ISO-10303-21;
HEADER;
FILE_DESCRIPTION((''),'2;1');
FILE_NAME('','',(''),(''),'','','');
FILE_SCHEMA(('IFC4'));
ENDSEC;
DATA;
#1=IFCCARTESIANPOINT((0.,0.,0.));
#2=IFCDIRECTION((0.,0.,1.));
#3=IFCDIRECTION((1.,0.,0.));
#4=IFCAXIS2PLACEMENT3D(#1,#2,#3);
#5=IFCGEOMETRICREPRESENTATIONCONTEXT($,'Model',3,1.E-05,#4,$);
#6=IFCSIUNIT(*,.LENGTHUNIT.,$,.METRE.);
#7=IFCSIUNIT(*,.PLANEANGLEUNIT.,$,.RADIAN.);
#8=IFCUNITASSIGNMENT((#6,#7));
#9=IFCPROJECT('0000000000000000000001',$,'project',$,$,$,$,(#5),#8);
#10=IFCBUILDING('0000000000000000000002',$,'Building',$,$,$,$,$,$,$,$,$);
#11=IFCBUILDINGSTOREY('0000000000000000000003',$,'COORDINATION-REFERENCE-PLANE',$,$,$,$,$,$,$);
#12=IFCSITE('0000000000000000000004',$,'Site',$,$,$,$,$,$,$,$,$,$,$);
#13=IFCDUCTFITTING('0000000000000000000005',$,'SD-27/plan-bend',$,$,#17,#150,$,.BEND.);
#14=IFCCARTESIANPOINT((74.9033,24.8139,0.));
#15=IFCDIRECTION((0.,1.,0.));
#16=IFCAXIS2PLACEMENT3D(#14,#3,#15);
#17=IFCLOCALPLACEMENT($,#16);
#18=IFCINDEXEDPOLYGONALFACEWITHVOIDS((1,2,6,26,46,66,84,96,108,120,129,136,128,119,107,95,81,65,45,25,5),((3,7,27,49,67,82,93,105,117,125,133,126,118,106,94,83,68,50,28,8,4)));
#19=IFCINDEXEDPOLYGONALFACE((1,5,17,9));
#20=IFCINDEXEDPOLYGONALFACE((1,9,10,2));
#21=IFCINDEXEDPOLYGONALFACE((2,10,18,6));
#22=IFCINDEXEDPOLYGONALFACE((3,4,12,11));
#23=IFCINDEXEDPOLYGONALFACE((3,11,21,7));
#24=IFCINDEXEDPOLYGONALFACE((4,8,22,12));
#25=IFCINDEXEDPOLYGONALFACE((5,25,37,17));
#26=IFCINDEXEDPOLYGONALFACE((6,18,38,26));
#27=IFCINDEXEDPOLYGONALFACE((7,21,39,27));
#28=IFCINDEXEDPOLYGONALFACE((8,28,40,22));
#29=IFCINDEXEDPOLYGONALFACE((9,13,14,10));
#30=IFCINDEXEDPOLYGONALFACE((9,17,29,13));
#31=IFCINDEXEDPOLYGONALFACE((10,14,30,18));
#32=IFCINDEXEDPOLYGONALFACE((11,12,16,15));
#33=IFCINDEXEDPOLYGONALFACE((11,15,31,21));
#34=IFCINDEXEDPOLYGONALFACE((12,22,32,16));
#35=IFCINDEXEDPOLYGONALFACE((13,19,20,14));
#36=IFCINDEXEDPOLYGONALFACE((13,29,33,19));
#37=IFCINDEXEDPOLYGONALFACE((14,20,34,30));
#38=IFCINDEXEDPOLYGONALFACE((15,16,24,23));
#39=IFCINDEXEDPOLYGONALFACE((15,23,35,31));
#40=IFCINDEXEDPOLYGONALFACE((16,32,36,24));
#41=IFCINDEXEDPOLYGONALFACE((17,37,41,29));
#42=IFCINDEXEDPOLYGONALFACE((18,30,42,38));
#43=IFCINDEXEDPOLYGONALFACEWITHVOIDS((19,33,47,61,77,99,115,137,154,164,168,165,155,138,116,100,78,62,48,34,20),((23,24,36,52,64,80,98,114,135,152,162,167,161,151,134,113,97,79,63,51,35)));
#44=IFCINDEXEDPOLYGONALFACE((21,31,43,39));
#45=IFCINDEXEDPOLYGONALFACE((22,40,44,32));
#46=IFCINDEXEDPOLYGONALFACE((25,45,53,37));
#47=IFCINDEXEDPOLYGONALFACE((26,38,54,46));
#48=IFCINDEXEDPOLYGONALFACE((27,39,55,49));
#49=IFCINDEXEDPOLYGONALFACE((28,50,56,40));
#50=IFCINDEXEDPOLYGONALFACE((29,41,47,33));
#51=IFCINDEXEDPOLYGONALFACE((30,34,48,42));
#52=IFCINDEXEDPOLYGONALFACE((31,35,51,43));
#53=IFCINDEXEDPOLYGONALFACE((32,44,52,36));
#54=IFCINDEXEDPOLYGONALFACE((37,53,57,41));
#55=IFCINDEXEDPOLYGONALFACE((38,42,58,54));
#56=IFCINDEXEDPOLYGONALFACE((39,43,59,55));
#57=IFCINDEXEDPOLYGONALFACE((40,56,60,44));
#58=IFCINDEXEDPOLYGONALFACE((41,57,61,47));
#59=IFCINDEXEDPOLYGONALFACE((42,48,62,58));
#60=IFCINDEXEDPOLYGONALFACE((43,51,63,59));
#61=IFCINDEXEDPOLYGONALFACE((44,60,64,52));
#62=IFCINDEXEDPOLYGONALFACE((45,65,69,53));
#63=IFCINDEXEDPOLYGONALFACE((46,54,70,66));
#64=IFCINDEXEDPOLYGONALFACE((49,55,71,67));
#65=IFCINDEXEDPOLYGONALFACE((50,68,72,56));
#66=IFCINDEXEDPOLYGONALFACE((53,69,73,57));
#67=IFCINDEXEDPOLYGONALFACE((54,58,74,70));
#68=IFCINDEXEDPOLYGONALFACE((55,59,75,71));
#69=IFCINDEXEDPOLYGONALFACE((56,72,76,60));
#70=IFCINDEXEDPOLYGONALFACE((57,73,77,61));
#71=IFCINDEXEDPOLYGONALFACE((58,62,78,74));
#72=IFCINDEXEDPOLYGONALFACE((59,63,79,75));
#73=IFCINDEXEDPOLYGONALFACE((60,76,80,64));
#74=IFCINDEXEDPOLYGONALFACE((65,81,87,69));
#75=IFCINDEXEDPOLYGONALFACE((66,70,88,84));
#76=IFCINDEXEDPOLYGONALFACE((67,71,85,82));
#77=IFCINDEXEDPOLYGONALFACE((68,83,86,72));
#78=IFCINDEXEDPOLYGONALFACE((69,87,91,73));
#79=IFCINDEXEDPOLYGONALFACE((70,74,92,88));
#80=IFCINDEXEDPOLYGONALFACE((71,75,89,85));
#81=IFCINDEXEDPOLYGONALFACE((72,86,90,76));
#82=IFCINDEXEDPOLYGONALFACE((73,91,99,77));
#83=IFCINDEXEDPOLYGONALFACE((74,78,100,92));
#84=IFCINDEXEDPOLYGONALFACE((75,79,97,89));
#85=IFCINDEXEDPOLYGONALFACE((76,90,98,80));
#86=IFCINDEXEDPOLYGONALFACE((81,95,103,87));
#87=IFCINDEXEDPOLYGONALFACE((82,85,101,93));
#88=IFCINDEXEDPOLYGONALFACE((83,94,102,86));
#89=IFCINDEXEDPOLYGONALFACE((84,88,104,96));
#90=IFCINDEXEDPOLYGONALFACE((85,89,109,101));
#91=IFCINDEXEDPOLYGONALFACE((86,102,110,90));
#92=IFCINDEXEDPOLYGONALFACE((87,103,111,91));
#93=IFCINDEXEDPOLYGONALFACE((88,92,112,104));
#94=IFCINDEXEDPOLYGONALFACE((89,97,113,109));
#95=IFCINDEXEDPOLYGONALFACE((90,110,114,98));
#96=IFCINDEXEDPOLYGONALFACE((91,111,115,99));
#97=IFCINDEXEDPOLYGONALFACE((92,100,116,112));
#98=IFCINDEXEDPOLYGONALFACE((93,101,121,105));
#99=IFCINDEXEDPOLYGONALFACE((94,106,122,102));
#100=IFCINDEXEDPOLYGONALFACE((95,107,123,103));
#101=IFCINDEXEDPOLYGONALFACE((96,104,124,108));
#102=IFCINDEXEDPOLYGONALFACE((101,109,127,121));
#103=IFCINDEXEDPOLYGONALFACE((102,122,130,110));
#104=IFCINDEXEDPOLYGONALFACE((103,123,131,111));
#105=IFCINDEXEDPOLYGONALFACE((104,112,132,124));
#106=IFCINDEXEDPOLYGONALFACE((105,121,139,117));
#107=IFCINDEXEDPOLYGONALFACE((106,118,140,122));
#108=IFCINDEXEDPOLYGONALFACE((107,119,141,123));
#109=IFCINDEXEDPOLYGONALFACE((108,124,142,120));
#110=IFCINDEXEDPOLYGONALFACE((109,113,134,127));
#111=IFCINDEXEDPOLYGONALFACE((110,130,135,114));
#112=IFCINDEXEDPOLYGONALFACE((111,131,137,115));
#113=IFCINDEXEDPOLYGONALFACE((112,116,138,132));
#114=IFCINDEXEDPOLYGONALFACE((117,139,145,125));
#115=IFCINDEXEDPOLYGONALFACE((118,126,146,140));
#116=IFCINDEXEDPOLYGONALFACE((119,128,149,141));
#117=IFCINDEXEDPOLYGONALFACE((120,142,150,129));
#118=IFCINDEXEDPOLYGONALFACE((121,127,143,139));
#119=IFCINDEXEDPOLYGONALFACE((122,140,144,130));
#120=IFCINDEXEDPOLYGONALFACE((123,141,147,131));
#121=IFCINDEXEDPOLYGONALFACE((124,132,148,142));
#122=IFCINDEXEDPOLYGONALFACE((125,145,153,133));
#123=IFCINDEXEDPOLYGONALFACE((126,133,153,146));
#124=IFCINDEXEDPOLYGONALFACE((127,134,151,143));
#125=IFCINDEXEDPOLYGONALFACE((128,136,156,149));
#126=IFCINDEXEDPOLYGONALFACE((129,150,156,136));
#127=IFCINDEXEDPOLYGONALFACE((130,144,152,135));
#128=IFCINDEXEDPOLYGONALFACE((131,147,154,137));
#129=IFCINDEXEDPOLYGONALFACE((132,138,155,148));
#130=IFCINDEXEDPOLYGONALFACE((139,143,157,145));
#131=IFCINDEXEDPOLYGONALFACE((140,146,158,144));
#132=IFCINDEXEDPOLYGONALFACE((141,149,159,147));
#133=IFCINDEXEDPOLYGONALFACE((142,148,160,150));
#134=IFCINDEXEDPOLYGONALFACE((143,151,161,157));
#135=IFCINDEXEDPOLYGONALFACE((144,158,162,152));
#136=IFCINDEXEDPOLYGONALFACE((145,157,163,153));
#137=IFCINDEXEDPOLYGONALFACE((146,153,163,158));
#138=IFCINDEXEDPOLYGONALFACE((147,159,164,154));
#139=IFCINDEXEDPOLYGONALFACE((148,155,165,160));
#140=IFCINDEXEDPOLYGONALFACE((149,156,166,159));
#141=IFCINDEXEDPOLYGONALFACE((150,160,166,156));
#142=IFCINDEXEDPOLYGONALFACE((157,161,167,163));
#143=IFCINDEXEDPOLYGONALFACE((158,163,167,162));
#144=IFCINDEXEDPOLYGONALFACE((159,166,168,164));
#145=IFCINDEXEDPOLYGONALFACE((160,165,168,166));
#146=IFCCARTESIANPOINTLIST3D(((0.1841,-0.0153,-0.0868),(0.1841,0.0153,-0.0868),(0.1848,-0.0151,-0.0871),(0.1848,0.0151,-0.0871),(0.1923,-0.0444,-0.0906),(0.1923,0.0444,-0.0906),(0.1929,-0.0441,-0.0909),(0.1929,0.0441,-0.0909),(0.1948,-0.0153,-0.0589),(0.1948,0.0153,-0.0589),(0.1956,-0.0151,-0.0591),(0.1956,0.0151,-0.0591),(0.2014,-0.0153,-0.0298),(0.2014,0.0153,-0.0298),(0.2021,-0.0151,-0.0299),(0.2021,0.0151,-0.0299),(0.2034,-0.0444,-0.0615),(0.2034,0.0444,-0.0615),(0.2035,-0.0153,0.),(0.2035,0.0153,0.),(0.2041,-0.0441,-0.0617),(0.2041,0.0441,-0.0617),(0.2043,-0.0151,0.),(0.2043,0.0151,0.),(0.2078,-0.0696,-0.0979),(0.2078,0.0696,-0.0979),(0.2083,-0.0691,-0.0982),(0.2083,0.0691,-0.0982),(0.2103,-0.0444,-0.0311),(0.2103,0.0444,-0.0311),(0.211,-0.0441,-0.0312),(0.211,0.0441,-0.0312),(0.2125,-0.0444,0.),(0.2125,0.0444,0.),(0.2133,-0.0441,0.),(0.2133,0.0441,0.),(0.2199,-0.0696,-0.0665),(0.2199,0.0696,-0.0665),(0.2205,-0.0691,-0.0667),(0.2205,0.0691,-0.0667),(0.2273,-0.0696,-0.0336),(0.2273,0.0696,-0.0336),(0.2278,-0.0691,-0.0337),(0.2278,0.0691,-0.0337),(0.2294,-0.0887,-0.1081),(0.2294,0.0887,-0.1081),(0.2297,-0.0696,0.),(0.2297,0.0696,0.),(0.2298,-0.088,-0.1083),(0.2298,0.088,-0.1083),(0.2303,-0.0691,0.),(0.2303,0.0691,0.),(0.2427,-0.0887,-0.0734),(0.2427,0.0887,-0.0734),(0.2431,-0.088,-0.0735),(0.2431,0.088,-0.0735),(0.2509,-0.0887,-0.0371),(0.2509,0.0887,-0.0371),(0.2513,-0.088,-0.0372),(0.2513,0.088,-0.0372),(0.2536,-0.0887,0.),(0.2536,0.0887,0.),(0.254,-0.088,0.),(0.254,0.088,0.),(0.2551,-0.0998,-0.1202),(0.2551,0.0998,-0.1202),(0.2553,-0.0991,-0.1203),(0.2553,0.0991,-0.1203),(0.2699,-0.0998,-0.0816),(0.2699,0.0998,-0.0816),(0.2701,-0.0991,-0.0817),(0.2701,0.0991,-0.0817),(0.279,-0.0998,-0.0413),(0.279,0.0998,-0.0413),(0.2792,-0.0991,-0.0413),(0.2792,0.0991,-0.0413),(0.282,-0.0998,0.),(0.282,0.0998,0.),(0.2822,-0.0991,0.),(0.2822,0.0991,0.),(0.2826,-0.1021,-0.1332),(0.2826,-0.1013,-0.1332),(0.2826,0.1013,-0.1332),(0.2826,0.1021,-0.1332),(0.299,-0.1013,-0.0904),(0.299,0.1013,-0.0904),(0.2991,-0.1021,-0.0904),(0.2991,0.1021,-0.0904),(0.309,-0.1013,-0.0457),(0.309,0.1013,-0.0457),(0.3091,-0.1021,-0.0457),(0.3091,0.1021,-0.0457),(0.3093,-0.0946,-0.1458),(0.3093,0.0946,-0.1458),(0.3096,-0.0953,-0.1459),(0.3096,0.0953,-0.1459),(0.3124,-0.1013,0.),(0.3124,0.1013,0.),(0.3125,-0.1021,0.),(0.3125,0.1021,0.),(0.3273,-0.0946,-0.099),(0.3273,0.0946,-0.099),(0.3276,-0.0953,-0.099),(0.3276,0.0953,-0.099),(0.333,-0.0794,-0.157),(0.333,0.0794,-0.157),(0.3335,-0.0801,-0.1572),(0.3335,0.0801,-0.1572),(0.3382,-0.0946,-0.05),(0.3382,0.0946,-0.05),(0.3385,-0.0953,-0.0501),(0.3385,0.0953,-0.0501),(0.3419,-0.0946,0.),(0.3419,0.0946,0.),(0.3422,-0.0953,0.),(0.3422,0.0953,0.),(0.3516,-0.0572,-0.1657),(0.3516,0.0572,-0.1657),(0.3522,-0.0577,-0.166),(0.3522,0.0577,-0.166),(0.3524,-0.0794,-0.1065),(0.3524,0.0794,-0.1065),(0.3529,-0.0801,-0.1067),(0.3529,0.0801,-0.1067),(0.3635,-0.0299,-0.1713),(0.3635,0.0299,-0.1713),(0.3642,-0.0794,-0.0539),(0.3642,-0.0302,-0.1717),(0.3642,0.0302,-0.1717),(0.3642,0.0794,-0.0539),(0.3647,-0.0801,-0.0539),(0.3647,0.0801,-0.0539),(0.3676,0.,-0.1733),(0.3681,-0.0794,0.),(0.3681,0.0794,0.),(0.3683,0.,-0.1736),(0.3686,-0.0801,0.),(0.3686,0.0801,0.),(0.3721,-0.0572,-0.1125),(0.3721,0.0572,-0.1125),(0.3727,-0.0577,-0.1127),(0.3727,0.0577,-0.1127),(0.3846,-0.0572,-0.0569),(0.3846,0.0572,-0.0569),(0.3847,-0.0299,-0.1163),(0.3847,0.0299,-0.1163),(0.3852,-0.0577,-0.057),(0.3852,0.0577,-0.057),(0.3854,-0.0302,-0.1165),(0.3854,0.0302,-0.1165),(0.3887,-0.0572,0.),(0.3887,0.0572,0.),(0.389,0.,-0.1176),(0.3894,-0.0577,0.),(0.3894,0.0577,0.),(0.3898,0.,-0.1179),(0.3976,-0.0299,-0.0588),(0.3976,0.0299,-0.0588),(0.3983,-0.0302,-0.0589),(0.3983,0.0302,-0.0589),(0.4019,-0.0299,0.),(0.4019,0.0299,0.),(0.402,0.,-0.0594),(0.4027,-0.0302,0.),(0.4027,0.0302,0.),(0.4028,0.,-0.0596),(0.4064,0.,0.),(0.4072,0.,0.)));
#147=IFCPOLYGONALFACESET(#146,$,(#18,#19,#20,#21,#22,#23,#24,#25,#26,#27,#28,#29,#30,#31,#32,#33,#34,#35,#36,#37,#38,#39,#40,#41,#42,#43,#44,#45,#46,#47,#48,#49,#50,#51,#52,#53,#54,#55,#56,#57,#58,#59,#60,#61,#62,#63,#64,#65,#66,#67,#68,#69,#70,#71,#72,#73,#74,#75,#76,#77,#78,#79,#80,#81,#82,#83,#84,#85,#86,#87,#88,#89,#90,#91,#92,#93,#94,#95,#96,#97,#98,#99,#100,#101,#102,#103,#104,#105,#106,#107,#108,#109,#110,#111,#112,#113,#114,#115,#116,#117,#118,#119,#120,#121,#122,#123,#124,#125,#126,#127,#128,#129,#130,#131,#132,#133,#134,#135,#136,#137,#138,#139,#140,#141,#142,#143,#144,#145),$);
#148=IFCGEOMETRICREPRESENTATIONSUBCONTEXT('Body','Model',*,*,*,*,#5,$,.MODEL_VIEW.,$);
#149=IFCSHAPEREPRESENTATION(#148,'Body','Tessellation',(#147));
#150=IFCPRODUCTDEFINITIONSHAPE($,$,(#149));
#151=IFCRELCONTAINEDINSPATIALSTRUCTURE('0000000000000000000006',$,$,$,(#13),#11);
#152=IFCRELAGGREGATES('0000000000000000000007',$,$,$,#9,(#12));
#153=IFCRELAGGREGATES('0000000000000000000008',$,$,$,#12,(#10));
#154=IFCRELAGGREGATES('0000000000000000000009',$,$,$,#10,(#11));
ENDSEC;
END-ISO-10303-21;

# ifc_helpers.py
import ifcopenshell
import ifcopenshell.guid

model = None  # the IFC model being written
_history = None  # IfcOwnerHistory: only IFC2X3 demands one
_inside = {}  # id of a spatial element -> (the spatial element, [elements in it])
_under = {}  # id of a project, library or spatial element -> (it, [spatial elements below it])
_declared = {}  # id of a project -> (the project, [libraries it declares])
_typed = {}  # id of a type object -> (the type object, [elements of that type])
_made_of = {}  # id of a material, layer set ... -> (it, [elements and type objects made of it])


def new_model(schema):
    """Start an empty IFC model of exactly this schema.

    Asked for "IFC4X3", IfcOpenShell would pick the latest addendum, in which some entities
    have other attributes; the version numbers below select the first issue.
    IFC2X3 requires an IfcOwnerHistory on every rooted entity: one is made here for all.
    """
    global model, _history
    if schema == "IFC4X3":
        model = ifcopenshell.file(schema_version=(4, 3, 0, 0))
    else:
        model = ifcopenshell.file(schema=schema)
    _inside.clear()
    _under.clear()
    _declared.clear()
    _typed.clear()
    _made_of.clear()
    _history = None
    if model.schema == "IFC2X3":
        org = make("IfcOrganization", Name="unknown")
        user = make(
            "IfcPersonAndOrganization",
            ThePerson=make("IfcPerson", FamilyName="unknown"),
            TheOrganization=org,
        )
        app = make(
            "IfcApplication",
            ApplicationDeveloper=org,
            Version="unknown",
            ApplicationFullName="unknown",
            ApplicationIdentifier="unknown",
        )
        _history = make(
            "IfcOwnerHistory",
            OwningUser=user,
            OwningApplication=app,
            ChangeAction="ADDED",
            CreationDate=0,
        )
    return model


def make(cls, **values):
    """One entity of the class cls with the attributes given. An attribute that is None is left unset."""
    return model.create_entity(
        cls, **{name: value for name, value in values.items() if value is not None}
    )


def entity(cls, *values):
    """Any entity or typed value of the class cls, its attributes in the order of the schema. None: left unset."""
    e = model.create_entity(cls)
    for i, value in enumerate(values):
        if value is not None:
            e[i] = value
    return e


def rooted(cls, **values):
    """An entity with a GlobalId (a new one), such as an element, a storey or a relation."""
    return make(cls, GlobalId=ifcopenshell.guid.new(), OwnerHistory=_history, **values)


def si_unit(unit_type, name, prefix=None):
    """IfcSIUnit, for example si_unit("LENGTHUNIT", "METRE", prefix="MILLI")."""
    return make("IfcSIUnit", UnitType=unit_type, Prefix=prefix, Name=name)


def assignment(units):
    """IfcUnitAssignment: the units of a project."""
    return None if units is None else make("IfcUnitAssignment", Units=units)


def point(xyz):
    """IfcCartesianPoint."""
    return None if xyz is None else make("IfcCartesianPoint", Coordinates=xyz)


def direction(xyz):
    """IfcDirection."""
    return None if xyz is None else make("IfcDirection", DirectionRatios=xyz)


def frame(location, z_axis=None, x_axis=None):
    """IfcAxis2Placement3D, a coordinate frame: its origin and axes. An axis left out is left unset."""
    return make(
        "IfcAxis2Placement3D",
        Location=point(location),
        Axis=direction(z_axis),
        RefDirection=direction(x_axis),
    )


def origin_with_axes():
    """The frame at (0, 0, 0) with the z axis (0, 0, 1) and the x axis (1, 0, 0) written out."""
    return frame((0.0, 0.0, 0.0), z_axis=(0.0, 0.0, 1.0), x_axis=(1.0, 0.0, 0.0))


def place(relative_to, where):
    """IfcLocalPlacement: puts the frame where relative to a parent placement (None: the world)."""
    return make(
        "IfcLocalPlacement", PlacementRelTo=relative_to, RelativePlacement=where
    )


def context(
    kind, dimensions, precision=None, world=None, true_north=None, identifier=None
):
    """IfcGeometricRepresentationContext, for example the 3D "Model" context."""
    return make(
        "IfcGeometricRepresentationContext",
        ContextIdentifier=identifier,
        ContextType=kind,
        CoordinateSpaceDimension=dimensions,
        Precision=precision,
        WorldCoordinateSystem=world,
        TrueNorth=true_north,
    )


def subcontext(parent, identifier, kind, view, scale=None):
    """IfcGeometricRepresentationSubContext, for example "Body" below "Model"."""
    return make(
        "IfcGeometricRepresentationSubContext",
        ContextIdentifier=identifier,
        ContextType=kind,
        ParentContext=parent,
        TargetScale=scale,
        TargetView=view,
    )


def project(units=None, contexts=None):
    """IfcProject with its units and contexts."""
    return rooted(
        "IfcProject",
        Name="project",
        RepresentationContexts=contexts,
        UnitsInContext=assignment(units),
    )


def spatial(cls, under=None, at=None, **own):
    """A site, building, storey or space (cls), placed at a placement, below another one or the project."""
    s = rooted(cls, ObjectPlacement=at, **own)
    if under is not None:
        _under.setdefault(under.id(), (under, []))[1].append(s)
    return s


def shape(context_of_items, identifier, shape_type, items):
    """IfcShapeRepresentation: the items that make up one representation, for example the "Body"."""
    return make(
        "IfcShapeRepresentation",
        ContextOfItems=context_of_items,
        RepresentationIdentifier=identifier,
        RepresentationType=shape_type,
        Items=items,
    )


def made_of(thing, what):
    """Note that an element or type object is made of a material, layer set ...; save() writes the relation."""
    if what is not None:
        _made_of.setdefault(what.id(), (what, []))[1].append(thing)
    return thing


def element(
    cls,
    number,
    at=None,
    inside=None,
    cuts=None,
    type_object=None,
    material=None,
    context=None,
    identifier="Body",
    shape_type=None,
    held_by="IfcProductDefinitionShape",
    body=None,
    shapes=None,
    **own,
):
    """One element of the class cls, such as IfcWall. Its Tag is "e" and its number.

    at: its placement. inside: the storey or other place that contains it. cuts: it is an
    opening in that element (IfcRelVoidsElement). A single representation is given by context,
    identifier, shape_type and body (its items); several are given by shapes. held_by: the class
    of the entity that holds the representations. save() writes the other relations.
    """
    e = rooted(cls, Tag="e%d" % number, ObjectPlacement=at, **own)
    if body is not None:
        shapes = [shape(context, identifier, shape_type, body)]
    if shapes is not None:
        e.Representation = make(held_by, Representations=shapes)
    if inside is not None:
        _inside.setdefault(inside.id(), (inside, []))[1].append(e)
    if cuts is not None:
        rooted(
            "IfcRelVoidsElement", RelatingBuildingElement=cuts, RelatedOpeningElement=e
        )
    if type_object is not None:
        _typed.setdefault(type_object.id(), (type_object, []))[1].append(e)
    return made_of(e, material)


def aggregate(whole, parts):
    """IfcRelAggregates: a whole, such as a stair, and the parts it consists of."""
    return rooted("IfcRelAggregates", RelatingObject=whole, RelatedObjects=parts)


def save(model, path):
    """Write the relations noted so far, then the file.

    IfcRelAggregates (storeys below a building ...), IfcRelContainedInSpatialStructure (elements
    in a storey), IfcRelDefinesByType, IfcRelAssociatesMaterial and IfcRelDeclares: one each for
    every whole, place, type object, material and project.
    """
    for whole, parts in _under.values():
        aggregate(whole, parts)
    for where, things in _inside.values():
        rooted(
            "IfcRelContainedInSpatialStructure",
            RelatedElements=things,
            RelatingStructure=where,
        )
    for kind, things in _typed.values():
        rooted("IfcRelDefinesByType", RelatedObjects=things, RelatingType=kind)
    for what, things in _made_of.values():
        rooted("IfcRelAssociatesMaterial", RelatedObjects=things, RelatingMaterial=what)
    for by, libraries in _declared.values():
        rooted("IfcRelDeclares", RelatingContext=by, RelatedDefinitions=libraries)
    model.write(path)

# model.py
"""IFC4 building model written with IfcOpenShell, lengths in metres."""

from ifc_helpers import new_model, entity, si_unit, frame, origin_with_axes, place, context, subcontext, project, spatial, element, save


model = new_model("IFC4")

# Units and contexts
model_context_1 = context("Model", 3, precision=1e-05, world=origin_with_axes())
body_context_1 = subcontext(model_context_1, "Body", "Model", "MODEL_VIEW")
ifc_project = project(units=[si_unit("LENGTHUNIT", "METRE"), si_unit("PLANEANGLEUNIT", "RADIAN")], contexts=[model_context_1])

# Site, building, storey
site = spatial("IfcSite", under=ifc_project, Name="Site")
building = spatial("IfcBuilding", under=site, Name="Building")
storey = spatial("IfcBuildingStorey", under=building, Name="COORDINATION-REFERENCE-PLANE")

# Duct fitting
duct_fitting_1_placement = place(None, frame((74.9033, 24.8139, 0.0), z_axis=(1.0, 0.0, 0.0), x_axis=(0.0, 1.0, 0.0)))
element("IfcDuctFitting", 1, at=duct_fitting_1_placement, inside=storey, Name="SD-27/plan-bend", PredefinedType="BEND", context=body_context_1, shape_type="SweptSolid", body=[
    entity("IfcRevolvedAreaSolid", entity("IfcCircleHollowProfileDef", "AREA", None, entity("IfcAxis2Placement2D", entity("IfcCartesianPoint", [0.3048, 0.0])), 0.1024, 0.0008), entity("IfcAxis2Placement3D", entity("IfcCartesianPoint", [0.0, 0.0, 0.0]), entity("IfcDirection", [0.0, 0.0, 1.0]), entity("IfcDirection", [1.0, 0.0, 0.0])), entity("IfcAxis1Placement", entity("IfcCartesianPoint", [0.0, 0.0, 0.0]), entity("IfcDirection", [0.0, 1.0, 0.0])), 0.440428),
])

save(model, "model.ifc")
